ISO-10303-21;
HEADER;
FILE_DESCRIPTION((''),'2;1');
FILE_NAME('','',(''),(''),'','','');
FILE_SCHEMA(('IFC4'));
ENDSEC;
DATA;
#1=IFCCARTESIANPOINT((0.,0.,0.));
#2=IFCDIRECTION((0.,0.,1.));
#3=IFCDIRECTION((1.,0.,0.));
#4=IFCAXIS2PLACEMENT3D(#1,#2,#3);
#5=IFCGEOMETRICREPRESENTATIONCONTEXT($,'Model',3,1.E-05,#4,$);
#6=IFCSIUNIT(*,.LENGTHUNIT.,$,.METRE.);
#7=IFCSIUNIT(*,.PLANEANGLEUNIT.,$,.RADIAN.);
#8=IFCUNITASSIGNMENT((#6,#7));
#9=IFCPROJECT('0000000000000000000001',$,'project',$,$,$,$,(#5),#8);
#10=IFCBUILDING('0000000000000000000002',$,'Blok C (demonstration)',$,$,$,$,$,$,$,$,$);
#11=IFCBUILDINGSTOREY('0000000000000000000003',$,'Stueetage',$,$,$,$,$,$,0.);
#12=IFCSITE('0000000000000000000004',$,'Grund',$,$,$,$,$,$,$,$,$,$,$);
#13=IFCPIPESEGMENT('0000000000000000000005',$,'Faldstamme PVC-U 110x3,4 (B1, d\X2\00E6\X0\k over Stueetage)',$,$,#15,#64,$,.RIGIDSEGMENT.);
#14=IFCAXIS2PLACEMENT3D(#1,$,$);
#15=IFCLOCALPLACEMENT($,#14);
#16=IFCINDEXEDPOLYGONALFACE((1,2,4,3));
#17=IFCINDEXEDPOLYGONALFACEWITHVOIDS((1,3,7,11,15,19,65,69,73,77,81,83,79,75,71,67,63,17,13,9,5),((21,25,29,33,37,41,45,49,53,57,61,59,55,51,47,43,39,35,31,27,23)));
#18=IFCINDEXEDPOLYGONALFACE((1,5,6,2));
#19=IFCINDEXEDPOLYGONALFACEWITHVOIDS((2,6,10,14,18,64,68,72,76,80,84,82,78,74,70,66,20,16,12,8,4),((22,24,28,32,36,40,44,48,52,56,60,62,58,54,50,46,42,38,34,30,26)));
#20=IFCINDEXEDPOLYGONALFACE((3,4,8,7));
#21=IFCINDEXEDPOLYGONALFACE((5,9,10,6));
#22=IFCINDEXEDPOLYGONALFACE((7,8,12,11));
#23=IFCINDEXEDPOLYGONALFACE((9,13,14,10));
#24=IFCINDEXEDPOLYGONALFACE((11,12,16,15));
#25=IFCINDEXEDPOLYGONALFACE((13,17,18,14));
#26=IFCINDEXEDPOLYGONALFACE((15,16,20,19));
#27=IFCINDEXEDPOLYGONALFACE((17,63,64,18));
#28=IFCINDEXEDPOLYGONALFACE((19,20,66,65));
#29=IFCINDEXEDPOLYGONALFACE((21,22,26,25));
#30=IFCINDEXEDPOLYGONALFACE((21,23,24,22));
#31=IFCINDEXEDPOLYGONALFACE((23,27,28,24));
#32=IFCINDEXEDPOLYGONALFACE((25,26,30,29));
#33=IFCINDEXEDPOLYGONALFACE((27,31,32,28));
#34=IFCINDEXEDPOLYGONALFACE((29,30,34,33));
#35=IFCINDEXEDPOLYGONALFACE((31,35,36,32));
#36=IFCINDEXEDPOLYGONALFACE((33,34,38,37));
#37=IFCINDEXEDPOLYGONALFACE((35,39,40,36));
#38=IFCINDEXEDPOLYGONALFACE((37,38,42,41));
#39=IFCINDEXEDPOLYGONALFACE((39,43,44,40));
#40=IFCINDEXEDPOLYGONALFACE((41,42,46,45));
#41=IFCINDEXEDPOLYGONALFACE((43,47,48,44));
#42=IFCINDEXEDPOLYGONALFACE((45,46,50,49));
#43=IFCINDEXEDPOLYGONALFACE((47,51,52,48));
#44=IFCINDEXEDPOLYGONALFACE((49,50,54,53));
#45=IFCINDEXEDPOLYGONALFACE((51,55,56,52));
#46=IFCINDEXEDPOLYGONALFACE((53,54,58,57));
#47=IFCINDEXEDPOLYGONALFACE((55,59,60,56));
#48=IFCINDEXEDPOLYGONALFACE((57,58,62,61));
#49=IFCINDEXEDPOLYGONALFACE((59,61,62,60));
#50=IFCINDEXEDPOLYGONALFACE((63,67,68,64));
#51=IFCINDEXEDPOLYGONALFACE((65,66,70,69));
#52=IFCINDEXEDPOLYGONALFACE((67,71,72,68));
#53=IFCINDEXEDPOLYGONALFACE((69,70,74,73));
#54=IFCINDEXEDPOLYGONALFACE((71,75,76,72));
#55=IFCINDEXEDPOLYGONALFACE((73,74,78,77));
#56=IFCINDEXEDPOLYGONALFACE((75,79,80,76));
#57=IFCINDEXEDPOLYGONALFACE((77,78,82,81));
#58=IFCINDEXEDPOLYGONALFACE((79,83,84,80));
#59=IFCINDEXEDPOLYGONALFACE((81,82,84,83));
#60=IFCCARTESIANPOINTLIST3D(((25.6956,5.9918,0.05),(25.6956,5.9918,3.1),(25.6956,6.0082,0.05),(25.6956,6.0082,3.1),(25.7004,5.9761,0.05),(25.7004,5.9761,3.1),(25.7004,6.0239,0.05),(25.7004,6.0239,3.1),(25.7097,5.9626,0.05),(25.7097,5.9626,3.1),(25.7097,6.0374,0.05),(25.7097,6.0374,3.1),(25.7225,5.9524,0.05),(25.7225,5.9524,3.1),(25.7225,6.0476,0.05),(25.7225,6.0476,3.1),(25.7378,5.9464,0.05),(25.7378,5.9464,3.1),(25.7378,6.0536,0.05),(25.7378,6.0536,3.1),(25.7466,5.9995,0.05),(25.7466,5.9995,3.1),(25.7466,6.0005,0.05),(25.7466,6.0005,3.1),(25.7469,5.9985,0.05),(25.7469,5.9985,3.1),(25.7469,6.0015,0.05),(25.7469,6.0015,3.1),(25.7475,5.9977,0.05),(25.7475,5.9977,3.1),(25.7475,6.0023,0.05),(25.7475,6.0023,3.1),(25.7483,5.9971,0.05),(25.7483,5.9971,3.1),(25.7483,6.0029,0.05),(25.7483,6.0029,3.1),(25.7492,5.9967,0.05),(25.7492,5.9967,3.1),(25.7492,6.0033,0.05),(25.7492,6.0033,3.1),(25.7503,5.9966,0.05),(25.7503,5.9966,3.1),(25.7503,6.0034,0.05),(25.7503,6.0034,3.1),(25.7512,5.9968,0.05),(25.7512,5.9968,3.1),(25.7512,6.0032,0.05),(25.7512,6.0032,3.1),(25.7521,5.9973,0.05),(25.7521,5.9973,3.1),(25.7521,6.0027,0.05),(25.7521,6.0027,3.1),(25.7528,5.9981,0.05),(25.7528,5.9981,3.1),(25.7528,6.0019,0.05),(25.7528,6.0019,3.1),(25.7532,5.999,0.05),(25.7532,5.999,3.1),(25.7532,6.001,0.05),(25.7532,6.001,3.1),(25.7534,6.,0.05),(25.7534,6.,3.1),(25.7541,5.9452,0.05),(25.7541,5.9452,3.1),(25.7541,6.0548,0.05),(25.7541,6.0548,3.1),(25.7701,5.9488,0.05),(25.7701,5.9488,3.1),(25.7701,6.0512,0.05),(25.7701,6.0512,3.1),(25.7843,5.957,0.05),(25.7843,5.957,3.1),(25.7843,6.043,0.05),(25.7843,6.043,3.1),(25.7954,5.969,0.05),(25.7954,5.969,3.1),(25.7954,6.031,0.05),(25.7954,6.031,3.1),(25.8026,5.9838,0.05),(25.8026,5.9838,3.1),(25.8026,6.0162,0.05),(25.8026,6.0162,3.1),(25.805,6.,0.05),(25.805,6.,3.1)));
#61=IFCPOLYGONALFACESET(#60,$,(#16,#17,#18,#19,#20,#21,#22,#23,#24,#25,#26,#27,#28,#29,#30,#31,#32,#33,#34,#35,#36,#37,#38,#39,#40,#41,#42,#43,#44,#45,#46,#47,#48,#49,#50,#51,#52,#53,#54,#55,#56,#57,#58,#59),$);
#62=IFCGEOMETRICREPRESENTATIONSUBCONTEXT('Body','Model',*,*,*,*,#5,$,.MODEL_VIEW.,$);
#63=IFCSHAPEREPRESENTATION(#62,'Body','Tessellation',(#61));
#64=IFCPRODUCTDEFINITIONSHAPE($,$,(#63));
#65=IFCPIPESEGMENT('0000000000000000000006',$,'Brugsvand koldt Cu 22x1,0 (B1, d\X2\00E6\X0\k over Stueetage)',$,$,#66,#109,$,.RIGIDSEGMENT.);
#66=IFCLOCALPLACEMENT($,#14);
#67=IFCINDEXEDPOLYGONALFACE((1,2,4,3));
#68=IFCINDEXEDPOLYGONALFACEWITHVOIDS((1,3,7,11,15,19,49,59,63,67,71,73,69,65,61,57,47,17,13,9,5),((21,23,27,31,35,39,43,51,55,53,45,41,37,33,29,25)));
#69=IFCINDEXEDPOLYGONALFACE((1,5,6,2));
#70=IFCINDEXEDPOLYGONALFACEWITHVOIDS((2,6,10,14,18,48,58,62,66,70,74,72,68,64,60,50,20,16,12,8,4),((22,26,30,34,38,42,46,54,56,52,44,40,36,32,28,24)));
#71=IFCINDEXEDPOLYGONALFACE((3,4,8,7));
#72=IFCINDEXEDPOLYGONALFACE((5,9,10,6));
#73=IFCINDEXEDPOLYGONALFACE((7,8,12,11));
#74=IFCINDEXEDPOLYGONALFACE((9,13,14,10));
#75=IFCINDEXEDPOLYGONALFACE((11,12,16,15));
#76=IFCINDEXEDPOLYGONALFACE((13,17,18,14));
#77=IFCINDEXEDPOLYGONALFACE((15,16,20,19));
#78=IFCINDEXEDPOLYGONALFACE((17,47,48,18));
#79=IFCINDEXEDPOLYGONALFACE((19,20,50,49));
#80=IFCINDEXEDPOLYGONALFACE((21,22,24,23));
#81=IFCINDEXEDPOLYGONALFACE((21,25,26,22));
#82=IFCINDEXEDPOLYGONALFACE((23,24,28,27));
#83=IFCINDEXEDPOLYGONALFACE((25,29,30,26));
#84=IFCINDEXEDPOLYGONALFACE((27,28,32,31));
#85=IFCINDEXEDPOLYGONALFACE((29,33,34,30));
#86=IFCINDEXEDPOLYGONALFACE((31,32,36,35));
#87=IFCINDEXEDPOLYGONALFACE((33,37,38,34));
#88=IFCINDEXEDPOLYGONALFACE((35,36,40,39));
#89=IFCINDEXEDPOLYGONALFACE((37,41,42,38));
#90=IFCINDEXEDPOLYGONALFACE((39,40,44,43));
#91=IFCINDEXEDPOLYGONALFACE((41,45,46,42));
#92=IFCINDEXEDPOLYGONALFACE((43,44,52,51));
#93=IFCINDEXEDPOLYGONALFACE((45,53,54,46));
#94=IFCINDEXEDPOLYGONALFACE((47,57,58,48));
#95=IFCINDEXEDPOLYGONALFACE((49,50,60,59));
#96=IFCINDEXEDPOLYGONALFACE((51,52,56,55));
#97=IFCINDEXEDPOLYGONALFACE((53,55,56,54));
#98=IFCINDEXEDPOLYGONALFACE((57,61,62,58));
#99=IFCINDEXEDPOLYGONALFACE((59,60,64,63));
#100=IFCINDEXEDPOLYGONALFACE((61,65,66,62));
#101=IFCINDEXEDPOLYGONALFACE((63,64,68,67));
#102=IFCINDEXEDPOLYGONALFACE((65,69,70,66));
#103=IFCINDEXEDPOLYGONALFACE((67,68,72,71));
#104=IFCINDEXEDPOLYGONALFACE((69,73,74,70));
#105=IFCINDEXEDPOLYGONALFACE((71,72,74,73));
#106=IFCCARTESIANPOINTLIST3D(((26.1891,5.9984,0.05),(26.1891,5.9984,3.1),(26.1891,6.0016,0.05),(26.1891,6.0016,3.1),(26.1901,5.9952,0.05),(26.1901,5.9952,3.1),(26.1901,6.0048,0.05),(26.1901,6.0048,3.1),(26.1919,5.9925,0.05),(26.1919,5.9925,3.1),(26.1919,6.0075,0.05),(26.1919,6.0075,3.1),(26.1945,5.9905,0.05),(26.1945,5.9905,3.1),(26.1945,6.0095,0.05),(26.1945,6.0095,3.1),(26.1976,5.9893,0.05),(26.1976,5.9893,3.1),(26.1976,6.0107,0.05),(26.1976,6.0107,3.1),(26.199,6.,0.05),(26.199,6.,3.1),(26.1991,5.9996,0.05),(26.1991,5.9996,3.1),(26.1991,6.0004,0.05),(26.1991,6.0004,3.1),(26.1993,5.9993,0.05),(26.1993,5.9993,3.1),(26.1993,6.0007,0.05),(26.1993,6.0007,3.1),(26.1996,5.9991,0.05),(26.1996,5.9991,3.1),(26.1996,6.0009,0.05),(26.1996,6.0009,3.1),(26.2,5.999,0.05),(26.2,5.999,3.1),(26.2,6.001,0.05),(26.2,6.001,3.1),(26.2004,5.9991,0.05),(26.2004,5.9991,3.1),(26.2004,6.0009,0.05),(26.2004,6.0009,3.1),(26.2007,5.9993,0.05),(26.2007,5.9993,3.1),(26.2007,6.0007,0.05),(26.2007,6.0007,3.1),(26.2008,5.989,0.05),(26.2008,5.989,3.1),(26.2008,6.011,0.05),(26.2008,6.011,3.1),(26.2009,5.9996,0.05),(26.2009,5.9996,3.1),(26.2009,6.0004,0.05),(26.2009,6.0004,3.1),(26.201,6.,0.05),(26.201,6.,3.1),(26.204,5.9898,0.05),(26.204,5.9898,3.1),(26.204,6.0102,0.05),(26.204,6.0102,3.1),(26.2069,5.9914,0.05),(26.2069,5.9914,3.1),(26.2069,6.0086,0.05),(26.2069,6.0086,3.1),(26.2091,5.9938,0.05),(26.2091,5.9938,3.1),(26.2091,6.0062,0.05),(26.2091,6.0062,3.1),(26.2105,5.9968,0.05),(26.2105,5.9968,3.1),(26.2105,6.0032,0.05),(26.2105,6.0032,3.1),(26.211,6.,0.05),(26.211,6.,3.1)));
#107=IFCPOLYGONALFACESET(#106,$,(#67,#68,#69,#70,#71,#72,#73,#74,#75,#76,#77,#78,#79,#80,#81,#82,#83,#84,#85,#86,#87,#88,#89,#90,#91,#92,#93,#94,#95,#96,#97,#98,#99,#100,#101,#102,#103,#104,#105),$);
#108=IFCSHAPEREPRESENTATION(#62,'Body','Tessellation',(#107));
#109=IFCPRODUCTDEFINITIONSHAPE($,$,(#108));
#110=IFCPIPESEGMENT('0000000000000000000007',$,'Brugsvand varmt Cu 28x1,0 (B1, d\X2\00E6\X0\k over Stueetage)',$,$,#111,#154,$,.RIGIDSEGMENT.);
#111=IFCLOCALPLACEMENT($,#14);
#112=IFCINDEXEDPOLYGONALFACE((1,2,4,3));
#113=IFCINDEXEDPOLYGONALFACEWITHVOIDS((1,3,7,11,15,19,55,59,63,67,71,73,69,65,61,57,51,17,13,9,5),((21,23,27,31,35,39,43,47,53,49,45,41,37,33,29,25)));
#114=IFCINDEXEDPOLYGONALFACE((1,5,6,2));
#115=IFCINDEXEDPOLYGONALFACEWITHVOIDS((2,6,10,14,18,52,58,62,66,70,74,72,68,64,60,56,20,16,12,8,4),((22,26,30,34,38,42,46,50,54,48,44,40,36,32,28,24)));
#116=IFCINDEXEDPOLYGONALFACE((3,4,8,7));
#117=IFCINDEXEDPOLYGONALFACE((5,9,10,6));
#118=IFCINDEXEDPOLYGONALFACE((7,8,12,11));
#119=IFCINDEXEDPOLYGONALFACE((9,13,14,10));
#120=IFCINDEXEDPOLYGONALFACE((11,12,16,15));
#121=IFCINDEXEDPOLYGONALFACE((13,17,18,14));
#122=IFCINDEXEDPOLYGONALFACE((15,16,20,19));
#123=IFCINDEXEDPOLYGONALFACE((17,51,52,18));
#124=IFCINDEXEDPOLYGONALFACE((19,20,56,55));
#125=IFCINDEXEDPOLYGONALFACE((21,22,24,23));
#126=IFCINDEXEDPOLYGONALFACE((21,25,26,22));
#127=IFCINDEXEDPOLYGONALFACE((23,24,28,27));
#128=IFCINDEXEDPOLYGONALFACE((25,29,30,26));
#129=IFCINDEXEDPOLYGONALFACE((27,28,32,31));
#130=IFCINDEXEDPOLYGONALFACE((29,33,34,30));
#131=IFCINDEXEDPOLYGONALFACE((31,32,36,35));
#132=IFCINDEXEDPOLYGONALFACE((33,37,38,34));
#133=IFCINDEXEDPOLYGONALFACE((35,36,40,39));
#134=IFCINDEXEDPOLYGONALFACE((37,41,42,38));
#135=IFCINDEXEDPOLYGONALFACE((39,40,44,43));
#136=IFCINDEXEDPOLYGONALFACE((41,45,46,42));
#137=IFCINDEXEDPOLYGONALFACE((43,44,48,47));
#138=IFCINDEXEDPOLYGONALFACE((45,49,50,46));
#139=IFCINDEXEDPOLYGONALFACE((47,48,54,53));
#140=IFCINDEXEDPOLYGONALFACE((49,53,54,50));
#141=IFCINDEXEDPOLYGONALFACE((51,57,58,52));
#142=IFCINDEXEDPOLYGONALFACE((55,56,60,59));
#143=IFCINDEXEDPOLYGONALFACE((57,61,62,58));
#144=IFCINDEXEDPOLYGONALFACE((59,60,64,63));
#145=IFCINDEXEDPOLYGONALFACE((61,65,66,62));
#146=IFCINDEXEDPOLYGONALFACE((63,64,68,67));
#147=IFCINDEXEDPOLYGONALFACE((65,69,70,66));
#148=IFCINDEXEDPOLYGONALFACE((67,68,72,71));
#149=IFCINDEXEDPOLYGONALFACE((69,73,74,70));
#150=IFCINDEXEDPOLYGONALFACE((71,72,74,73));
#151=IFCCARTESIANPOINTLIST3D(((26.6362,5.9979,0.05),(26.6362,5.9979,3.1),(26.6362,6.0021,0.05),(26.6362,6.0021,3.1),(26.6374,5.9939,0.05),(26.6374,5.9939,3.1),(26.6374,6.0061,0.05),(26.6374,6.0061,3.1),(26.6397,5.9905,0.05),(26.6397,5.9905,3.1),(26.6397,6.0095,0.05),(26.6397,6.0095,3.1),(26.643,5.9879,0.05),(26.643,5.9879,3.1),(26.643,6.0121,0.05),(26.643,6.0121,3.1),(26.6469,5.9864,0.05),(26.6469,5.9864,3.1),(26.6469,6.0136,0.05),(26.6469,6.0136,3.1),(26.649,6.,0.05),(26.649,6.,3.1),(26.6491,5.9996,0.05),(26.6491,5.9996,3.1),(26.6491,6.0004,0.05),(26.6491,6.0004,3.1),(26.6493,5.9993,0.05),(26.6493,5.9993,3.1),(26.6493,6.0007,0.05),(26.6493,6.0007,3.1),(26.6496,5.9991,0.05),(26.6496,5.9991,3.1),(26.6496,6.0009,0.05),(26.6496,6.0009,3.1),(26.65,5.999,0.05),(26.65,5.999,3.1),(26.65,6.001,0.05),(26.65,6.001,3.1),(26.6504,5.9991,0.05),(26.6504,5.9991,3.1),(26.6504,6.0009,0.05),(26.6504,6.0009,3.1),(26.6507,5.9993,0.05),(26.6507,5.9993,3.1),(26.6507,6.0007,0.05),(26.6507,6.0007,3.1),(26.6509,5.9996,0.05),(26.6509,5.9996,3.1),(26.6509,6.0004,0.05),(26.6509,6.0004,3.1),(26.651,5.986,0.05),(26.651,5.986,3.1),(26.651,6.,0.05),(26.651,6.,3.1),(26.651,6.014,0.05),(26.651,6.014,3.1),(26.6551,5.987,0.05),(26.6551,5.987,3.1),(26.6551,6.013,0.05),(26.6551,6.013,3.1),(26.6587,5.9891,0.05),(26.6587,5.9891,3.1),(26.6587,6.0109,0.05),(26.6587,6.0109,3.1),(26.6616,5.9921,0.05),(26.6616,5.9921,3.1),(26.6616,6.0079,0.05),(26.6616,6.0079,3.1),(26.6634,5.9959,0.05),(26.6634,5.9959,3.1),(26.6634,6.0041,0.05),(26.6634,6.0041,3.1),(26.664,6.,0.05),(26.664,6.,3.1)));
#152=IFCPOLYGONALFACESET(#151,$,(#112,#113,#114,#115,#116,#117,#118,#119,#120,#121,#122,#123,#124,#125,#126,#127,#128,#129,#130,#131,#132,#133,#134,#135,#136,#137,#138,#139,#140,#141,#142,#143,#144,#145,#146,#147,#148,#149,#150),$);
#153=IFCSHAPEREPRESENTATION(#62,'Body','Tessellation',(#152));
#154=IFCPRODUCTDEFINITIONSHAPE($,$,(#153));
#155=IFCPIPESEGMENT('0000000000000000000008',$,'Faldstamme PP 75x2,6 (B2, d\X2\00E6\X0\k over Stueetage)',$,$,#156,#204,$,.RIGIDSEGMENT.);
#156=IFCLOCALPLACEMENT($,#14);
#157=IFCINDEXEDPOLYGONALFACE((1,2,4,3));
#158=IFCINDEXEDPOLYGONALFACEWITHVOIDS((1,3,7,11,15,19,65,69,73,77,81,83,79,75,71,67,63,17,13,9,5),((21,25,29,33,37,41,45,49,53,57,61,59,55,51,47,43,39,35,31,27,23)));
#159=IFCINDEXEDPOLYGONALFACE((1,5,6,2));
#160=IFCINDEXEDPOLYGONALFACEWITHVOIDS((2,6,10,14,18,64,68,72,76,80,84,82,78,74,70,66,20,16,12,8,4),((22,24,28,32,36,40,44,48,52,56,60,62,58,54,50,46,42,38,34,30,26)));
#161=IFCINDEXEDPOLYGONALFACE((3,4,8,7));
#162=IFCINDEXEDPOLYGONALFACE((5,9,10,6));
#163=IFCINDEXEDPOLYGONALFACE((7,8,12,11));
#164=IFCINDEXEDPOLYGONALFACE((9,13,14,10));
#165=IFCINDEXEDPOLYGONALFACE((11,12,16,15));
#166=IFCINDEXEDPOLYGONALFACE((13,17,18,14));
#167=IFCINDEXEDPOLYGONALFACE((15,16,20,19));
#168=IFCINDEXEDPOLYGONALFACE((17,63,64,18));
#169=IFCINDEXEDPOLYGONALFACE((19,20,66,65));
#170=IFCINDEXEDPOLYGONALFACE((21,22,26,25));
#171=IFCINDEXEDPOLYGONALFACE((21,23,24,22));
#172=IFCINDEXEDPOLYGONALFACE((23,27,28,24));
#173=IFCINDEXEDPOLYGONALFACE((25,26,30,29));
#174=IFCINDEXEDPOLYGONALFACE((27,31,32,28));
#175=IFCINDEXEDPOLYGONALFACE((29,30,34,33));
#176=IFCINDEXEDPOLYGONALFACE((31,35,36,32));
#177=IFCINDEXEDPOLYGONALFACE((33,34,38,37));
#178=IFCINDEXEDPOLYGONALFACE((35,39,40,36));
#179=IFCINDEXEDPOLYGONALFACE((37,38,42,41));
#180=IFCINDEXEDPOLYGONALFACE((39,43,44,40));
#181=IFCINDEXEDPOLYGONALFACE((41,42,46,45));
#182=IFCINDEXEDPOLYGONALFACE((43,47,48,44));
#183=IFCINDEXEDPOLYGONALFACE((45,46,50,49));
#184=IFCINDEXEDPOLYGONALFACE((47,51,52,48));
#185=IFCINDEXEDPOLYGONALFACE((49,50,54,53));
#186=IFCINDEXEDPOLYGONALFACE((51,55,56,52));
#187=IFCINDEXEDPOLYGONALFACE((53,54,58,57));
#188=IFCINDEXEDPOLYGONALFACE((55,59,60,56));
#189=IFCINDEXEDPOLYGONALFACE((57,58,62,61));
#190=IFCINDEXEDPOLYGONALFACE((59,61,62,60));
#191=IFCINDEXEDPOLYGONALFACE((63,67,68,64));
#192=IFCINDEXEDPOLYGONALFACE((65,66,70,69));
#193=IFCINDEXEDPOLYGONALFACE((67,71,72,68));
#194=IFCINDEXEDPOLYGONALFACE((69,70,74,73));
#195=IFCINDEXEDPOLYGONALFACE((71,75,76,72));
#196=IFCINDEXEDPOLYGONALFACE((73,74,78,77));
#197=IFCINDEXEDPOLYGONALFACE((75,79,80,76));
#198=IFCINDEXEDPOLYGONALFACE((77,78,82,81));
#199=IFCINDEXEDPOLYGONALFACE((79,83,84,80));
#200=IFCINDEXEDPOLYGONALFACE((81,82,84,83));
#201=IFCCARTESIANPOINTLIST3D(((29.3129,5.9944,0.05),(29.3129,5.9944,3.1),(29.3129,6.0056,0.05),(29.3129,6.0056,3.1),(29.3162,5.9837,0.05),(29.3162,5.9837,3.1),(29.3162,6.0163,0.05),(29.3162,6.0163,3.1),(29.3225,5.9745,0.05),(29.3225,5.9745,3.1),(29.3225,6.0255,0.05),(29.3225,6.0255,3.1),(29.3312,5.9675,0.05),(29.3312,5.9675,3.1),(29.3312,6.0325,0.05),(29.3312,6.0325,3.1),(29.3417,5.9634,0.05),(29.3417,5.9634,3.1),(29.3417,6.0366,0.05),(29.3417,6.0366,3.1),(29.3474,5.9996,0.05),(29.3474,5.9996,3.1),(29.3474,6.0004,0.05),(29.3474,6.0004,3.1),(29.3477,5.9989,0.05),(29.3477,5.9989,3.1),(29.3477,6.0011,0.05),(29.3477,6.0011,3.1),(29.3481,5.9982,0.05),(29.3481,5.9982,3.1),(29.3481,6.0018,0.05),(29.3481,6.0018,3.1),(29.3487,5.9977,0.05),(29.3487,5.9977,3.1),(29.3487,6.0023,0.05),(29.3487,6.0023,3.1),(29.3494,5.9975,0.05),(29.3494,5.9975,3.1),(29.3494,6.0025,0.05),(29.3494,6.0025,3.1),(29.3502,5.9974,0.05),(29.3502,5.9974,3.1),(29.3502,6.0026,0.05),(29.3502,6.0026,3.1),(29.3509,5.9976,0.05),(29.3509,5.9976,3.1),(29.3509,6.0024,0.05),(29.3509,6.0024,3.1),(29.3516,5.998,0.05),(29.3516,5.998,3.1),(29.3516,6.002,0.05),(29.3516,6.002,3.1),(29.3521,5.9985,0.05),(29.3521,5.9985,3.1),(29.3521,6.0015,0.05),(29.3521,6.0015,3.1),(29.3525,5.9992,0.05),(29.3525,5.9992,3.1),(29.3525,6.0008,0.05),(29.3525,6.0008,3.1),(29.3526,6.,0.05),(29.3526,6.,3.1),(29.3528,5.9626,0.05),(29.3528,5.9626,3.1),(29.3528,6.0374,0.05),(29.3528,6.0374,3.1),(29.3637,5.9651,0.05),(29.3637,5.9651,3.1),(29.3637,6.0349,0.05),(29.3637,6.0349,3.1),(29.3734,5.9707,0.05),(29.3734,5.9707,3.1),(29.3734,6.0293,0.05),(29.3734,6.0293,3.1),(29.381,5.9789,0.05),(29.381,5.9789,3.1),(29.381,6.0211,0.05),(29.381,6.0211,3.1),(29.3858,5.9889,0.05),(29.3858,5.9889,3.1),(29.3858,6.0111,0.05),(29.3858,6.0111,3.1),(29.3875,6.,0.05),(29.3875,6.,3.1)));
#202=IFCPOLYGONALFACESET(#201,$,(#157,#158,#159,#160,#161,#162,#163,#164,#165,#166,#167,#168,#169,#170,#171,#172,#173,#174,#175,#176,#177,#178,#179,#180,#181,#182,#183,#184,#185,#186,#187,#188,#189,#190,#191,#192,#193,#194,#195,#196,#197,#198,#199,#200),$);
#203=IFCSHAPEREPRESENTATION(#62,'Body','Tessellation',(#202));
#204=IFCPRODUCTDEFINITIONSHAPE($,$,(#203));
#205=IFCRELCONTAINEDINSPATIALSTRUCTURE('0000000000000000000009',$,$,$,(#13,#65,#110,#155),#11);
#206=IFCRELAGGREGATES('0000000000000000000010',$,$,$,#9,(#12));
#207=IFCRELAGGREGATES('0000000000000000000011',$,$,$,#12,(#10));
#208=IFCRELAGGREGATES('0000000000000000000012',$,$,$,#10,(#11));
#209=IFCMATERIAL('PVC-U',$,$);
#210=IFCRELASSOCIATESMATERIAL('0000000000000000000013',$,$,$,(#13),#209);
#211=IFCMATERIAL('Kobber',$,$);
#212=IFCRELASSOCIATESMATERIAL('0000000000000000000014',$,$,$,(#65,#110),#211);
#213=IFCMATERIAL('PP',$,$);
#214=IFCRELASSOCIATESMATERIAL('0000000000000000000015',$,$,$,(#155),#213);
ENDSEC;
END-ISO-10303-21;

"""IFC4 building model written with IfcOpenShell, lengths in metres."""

from ifc_helpers import new_model, si_unit, frame, origin_with_axes, place, context, subcontext, project, spatial, hollow_circle, extrude, material, element, save


model = new_model("IFC4")

# Units and contexts
model_context = context("Model", 3, precision=1e-05, world=origin_with_axes())
body_context = subcontext(model_context, "Body", "Model", "MODEL_VIEW")
ifc_project = project(units=[si_unit("LENGTHUNIT", "METRE"), si_unit("PLANEANGLEUNIT", "RADIAN")], contexts=[model_context])

# Site, building, storey
site = spatial("IfcSite", under=ifc_project, Name="Grund")
building = spatial("IfcBuilding", under=site, Name="Blok C (demonstration)")
storey = spatial("IfcBuildingStorey", under=building, Name="Stueetage", Elevation=0.0)

# Pipe segments
ifc_material_1 = material(Name="PVC-U")
pipe_segment_1_placement = place(None, origin_with_axes())
element("IfcPipeSegment", 1, at=pipe_segment_1_placement, inside=storey, material=ifc_material_1, Name="Faldstamme PVC-U 110x3,4 (B1, dæk over Stueetage)", PredefinedType="RIGIDSEGMENT", context=body_context, shape_type="SweptSolid", body=[
    extrude(hollow_circle(Radius=0.055, WallThickness=0.0516), frame((25.75, 6.0, 0.05), z_axis=(0.0, 0.0, 1.0), x_axis=(1.0, 0.0, 0.0)), (0.0, 0.0, 1.0), 3.05),
])
ifc_material_2 = material(Name="Kobber")
pipe_segment_2_placement = place(None, origin_with_axes())
element("IfcPipeSegment", 2, at=pipe_segment_2_placement, inside=storey, material=ifc_material_2, Name="Brugsvand koldt Cu 22x1,0 (B1, dæk over Stueetage)", PredefinedType="RIGIDSEGMENT", context=body_context, shape_type="SweptSolid", body=[
    extrude(hollow_circle(Radius=0.011, WallThickness=0.01), frame((26.2, 6.0, 0.05), z_axis=(0.0, 0.0, 1.0), x_axis=(1.0, 0.0, 0.0)), (0.0, 0.0, 1.0), 3.05),
])
pipe_segment_3_placement = place(None, origin_with_axes())
element("IfcPipeSegment", 3, at=pipe_segment_3_placement, inside=storey, material=ifc_material_2, Name="Brugsvand varmt Cu 28x1,0 (B1, dæk over Stueetage)", PredefinedType="RIGIDSEGMENT", context=body_context, shape_type="SweptSolid", body=[
    extrude(hollow_circle(Radius=0.014, WallThickness=0.013), frame((26.65, 6.0, 0.05), z_axis=(0.0, 0.0, 1.0), x_axis=(1.0, 0.0, 0.0)), (0.0, 0.0, 1.0), 3.05),
])
ifc_material_3 = material(Name="PP")
pipe_segment_4_placement = place(None, origin_with_axes())
element("IfcPipeSegment", 4, at=pipe_segment_4_placement, inside=storey, material=ifc_material_3, Name="Faldstamme PP 75x2,6 (B2, dæk over Stueetage)", PredefinedType="RIGIDSEGMENT", context=body_context, shape_type="SweptSolid", body=[
    extrude(hollow_circle(Radius=0.0375, WallThickness=0.0349), frame((29.35, 6.0, 0.05), z_axis=(0.0, 0.0, 1.0), x_axis=(1.0, 0.0, 0.0)), (0.0, 0.0, 1.0), 3.05),
])

save(model, "model.ifc")
